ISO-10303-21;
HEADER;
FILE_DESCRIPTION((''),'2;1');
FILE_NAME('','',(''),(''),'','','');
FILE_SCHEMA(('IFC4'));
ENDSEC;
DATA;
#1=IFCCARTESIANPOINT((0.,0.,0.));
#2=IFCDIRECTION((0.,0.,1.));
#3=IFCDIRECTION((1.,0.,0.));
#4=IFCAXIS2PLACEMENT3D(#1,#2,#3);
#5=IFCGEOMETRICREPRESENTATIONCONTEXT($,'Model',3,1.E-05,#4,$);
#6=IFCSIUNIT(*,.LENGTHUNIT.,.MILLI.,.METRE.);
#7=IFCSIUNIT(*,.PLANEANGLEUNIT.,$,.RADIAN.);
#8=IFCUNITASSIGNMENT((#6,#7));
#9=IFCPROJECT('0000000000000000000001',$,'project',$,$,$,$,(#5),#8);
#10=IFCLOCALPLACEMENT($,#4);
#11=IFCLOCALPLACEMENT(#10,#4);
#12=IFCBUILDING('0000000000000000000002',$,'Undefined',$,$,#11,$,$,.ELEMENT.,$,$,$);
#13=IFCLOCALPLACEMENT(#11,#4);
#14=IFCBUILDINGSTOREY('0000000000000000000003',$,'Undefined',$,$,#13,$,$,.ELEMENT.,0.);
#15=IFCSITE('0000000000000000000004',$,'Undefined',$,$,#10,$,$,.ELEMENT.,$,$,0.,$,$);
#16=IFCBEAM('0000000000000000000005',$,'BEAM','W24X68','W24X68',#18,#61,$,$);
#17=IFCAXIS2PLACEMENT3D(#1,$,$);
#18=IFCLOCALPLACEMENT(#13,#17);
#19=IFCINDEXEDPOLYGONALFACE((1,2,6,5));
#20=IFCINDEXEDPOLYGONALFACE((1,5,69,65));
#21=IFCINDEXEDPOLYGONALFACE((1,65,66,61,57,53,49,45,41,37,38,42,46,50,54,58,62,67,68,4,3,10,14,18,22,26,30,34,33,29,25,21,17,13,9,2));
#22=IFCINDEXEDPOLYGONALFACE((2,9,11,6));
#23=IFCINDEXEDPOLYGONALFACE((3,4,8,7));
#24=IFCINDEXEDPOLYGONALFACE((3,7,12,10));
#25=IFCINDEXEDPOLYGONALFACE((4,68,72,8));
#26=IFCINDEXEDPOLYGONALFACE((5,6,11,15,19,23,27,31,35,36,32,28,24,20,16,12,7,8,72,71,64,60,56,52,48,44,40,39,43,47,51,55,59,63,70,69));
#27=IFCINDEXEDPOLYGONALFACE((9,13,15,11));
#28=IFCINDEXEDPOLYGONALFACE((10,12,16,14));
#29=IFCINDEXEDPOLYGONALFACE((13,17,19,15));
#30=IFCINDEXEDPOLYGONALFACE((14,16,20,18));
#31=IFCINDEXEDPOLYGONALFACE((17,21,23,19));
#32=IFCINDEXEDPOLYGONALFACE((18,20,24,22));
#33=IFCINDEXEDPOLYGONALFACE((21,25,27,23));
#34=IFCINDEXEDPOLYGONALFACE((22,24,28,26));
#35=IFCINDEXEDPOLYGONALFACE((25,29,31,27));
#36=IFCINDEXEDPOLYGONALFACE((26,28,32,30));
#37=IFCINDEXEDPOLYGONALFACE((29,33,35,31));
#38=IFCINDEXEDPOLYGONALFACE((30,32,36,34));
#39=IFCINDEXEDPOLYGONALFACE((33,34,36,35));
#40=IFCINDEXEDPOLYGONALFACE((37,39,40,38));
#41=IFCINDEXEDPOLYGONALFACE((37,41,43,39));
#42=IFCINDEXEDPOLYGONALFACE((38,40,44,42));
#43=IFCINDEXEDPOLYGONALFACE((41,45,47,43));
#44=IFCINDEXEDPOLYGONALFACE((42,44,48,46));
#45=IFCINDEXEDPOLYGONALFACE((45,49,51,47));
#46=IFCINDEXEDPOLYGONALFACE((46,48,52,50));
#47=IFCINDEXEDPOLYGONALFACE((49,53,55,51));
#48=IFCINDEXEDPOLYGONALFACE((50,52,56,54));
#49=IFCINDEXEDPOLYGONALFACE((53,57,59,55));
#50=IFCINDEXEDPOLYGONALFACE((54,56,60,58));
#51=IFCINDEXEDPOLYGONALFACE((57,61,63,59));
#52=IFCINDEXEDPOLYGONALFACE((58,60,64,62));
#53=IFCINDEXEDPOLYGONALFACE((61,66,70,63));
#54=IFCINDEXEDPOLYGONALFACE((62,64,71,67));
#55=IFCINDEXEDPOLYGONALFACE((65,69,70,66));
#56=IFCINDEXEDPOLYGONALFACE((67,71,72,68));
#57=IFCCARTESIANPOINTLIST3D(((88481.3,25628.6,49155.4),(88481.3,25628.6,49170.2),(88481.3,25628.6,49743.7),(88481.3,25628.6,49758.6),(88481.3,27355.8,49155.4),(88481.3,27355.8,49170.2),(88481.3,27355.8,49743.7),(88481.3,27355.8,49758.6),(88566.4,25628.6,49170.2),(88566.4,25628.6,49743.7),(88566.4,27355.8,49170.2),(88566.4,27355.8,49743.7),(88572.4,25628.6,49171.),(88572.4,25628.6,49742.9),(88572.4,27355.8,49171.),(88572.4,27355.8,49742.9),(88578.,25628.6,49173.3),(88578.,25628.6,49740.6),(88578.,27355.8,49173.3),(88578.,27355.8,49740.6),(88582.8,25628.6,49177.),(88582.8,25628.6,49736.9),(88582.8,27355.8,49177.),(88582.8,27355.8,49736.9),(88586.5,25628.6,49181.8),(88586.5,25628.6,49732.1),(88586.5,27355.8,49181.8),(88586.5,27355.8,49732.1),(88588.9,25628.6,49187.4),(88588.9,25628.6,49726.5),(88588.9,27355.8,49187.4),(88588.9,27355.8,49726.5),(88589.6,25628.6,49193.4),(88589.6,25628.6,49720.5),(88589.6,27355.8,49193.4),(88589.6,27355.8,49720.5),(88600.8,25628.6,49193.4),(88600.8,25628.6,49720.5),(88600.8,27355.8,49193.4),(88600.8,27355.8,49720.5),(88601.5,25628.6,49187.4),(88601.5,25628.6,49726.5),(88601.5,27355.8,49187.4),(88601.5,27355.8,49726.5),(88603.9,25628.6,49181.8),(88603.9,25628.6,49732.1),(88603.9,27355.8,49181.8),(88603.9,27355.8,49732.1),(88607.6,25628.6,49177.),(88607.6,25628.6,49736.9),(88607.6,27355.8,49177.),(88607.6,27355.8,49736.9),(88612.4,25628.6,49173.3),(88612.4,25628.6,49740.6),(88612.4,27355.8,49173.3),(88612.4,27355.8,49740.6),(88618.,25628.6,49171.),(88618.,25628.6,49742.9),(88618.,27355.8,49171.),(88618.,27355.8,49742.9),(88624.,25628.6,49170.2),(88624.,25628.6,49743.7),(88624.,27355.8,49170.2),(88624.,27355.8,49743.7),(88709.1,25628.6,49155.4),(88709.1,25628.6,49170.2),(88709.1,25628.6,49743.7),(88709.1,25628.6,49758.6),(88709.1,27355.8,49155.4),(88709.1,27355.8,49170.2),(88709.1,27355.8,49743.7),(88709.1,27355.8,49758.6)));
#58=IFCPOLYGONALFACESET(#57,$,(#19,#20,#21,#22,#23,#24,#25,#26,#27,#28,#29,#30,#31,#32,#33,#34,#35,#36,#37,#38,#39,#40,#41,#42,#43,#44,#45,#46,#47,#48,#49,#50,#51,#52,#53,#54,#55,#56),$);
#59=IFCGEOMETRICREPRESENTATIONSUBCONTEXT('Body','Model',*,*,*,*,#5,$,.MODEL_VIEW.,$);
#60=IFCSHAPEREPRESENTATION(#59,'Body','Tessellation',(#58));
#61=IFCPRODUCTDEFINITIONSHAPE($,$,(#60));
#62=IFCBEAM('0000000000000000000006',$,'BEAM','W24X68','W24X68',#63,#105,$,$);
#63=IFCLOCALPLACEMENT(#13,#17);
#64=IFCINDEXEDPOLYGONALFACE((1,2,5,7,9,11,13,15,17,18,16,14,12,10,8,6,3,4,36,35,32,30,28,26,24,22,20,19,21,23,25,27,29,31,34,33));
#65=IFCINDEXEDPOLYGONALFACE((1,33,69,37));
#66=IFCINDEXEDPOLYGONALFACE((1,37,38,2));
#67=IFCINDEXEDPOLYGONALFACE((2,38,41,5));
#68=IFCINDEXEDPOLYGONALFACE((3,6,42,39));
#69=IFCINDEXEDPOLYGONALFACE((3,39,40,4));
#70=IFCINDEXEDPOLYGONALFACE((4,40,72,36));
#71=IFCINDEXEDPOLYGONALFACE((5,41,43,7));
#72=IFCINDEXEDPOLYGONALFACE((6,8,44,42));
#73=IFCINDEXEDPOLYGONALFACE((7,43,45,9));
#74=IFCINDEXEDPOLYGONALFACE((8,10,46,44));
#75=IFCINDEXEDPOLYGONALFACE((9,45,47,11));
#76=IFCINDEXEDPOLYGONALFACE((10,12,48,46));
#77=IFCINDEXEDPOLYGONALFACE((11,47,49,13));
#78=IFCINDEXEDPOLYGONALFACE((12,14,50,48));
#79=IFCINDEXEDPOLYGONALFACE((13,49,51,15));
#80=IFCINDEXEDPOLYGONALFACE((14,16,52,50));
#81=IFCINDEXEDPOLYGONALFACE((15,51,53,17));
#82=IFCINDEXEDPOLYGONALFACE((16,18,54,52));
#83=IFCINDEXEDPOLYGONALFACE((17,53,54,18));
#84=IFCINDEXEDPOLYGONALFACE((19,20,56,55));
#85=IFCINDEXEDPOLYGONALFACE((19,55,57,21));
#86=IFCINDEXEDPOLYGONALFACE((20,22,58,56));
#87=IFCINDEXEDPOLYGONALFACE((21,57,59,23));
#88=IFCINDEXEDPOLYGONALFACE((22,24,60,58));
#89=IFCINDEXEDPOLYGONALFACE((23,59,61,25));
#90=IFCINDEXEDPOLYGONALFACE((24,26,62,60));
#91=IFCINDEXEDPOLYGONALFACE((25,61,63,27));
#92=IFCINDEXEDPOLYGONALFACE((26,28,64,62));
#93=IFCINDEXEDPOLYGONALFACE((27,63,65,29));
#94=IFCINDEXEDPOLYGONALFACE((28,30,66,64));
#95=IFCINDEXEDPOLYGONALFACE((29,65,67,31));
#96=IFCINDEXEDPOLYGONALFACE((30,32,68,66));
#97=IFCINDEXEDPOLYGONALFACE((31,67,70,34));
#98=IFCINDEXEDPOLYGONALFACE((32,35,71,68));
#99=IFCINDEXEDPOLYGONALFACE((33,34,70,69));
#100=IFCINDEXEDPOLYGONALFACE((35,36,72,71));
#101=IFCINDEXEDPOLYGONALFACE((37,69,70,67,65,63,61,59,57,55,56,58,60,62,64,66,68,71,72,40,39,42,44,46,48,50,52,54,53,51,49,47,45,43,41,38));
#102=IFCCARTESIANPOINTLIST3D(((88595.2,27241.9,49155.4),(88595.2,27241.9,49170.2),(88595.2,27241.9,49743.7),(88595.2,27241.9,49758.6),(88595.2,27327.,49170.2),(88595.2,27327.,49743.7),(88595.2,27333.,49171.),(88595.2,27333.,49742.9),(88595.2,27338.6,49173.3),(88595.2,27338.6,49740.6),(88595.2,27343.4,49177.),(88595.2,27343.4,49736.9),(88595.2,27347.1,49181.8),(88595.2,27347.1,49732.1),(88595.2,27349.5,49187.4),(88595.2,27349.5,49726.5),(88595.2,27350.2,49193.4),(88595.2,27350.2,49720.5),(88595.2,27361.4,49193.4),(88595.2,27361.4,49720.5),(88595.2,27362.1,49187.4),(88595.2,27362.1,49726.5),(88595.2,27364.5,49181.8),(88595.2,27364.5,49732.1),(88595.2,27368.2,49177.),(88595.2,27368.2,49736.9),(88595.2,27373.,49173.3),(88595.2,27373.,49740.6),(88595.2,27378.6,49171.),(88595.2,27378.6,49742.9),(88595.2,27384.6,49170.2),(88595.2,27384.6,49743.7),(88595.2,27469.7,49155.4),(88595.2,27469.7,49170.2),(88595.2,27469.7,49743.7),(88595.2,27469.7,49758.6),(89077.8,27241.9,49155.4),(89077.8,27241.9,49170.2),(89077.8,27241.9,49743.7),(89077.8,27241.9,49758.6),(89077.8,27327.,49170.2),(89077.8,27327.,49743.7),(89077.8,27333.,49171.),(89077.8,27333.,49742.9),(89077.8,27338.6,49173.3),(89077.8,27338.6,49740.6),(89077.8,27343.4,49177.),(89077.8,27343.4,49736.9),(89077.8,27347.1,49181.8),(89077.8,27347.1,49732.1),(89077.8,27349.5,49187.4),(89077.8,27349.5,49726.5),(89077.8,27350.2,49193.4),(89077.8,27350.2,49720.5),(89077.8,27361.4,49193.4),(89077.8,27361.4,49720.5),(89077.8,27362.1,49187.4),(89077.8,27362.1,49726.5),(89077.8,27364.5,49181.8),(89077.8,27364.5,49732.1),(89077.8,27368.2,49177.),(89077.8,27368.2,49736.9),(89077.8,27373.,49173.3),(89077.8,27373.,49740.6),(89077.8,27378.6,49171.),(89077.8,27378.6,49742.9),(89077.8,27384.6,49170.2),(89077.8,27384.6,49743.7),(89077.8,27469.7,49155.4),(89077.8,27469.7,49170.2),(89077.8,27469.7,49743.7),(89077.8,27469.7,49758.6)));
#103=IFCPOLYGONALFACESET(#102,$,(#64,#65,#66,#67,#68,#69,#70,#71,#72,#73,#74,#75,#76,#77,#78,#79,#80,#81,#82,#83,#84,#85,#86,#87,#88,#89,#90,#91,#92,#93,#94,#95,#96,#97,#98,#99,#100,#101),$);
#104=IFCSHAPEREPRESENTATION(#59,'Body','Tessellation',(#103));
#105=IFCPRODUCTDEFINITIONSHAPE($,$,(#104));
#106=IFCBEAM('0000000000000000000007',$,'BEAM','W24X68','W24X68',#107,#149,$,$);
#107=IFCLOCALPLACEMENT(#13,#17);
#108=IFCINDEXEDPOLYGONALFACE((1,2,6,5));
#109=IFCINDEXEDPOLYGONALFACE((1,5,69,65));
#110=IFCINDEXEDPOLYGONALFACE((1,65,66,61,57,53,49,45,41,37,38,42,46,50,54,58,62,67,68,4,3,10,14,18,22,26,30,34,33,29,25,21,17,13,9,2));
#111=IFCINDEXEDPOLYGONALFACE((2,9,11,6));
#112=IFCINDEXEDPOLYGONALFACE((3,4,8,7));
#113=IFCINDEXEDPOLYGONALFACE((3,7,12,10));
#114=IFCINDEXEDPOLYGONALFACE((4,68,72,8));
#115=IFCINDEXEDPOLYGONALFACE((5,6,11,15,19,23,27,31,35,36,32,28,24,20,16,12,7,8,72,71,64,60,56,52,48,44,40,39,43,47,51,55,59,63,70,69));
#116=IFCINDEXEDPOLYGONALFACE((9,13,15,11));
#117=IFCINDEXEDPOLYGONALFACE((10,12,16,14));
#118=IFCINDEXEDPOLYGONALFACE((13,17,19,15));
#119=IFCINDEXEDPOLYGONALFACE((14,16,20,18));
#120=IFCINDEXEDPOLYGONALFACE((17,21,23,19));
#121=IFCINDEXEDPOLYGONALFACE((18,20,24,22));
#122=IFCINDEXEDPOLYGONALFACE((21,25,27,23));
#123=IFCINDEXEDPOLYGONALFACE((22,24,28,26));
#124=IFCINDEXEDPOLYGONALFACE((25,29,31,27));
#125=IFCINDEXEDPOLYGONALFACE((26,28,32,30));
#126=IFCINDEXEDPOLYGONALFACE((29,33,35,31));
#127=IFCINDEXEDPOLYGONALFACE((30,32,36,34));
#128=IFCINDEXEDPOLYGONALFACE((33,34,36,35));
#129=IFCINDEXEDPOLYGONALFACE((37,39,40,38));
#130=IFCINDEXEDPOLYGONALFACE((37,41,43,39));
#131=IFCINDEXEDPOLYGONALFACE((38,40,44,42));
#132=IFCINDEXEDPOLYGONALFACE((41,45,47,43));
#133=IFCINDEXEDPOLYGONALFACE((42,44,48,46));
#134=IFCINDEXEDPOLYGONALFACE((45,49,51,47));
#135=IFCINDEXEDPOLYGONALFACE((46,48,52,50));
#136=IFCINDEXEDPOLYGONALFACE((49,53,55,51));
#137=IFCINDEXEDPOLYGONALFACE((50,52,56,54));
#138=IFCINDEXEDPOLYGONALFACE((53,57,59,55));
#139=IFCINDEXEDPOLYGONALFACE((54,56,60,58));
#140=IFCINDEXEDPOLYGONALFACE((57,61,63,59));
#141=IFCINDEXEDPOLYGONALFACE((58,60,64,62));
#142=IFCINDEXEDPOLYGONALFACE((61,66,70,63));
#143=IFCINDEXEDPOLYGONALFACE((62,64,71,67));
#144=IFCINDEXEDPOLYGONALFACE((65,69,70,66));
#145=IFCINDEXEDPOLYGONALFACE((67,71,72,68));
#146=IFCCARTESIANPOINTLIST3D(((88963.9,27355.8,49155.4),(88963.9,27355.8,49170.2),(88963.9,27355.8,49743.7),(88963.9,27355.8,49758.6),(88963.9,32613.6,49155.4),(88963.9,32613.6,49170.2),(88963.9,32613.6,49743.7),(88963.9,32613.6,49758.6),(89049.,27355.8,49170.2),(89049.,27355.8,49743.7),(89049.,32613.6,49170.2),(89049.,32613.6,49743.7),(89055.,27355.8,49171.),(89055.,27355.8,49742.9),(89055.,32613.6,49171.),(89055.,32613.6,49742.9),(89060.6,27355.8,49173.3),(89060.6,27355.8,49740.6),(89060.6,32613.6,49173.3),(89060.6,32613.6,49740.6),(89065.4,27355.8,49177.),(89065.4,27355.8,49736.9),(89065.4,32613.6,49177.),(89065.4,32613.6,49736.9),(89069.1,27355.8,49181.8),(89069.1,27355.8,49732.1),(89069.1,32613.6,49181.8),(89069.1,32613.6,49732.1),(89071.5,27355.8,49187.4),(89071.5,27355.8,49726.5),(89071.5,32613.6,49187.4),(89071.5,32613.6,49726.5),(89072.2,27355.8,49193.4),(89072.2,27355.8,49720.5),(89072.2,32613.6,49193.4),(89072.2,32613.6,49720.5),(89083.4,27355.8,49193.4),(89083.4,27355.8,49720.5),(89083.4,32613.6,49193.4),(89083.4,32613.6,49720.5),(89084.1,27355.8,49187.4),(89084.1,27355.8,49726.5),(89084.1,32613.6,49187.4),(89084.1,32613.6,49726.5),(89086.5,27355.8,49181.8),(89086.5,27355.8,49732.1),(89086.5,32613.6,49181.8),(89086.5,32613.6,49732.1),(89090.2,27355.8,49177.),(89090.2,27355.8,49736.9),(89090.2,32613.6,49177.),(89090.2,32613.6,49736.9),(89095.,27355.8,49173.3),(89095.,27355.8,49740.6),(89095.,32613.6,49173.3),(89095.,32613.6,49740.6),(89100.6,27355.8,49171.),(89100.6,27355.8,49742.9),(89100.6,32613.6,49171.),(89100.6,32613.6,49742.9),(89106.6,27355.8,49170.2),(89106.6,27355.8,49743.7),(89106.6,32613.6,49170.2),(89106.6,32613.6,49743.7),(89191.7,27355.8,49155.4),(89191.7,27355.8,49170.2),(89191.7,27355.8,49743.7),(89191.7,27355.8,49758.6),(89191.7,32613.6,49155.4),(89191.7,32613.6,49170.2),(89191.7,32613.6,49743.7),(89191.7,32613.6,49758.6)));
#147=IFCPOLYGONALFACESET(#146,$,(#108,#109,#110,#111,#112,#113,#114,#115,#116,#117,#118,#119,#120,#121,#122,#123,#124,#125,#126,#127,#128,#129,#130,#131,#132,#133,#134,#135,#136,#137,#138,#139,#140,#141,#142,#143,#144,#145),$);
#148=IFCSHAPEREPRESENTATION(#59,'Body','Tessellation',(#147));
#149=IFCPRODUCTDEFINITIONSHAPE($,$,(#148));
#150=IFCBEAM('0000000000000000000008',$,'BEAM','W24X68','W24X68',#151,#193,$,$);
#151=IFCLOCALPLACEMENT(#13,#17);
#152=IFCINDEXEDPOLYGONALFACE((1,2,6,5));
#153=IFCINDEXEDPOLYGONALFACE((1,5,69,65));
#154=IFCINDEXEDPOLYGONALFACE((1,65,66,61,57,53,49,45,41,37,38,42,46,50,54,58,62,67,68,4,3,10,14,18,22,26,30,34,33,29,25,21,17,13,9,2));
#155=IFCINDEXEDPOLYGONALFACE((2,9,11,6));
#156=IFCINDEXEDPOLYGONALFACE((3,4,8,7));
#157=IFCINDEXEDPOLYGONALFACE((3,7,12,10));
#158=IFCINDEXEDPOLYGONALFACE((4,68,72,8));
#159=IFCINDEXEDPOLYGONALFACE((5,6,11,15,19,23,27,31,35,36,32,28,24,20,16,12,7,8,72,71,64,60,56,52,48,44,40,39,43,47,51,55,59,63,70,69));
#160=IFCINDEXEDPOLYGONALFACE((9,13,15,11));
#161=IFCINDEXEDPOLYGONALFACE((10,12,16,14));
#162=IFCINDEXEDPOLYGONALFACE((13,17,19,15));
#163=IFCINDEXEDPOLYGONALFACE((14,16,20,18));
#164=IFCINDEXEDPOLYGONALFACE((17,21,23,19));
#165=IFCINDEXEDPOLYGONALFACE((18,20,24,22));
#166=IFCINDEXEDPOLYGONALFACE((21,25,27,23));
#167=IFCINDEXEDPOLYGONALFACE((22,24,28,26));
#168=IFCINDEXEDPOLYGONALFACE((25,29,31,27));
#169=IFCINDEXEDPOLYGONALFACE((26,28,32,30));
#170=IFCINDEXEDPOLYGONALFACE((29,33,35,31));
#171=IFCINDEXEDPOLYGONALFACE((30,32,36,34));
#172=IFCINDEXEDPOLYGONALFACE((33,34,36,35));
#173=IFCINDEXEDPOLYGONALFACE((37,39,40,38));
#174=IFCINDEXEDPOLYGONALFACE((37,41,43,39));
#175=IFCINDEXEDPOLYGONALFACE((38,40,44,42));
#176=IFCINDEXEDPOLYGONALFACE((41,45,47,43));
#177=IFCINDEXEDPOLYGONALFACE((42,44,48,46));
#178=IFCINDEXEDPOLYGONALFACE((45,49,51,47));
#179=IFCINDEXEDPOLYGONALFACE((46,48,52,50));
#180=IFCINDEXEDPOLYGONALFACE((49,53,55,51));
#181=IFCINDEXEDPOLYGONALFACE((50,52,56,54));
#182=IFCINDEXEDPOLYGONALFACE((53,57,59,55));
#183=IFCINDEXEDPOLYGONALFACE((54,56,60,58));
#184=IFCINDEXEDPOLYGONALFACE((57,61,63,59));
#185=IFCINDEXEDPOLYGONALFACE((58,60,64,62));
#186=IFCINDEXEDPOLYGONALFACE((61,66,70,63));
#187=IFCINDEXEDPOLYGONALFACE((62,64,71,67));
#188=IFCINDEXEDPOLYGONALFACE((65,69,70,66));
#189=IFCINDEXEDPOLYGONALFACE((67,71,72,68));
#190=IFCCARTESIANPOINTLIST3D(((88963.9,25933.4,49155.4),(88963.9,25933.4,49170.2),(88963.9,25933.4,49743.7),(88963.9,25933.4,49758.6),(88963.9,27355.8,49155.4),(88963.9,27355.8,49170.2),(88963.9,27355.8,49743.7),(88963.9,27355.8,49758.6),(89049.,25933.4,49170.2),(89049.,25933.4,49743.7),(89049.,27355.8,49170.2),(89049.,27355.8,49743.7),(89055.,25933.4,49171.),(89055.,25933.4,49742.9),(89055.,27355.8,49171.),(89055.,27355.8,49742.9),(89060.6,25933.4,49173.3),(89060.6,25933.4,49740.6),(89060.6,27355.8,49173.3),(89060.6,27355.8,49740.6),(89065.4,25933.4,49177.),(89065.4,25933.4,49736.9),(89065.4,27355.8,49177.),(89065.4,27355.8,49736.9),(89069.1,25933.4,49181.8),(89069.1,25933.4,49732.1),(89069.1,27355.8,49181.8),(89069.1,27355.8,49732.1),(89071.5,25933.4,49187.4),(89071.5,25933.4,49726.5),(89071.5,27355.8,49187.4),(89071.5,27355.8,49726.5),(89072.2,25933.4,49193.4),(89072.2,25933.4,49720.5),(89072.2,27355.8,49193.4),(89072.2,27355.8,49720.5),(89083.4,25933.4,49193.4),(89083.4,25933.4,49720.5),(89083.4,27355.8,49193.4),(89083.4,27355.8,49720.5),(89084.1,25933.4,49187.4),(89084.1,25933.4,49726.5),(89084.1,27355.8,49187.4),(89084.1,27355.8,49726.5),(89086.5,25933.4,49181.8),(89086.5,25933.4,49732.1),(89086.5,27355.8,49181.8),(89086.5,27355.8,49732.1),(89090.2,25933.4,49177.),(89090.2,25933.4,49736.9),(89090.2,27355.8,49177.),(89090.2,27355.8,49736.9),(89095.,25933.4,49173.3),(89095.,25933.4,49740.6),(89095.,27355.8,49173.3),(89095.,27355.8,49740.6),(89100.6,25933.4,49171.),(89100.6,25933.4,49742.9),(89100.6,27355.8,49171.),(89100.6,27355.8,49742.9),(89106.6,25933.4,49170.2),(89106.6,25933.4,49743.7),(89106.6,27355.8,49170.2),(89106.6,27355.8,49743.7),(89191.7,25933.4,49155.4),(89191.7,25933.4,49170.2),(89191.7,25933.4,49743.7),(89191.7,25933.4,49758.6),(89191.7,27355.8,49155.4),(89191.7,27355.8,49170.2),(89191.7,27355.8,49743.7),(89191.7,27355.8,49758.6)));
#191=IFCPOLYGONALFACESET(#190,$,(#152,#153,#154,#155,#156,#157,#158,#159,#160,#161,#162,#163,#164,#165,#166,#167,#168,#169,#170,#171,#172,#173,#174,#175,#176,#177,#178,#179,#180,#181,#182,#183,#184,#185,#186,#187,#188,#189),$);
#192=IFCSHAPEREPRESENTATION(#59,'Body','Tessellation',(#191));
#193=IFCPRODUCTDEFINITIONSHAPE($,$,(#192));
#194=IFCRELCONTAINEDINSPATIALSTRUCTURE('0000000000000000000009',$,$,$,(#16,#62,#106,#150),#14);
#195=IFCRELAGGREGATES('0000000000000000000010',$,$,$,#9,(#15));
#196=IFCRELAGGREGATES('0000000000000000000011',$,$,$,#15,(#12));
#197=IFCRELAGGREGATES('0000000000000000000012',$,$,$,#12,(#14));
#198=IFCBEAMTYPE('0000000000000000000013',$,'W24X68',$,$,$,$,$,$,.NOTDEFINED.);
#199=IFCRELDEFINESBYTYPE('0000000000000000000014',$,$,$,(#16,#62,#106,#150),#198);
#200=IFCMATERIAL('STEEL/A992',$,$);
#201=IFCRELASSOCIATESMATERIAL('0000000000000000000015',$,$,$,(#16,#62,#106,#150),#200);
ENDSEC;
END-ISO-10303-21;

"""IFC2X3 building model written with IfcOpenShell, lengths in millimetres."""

from ifc_helpers import new_model, si_unit, frame, origin_with_axes, origin_2d_with_axis, place, context, subcontext, project, spatial, i_section, extrude, material, type_object, element, save


model = new_model("IFC2X3")

# Units and contexts
model_context = context("Model", 3, precision=1e-05, world=origin_with_axes())
body_context = subcontext(model_context, "Body", "Model", "MODEL_VIEW")
ifc_project = project(units=[si_unit("LENGTHUNIT", "METRE", prefix="MILLI"), si_unit("PLANEANGLEUNIT", "RADIAN")], contexts=[model_context])

# Site, building, storey
site_placement = place(None, origin_with_axes())
site = spatial("IfcSite", under=ifc_project, at=site_placement, Name="Undefined", CompositionType="ELEMENT", RefElevation=0.0)
building_placement = place(site_placement, origin_with_axes())
building = spatial("IfcBuilding", under=site, at=building_placement, Name="Undefined", CompositionType="ELEMENT")
storey_placement = place(building_placement, origin_with_axes())
storey = spatial("IfcBuildingStorey", under=building, at=storey_placement, Name="Undefined", CompositionType="ELEMENT", Elevation=0.0)

# Shared definitions
ifc_material = material(Name="STEEL/A992")

# Beams
beam_type = type_object("IfcBeamType", Name="W24X68", PredefinedType="NOTDEFINED")
for number, where, z_axis, x_axis, name in (
    (1, (88595.2, 25628.6, 49457.0), (0.0, 0.0, 1.0), (0.0, 1.0, 0.0), "BEAM"),
):
    element("IfcBeam", number, at=place(storey_placement, frame(where, z_axis=z_axis, x_axis=x_axis)), inside=storey, type_object=beam_type, material=ifc_material, Name=name, Description="W24X68", ObjectType="W24X68", context=body_context, shape_type="SweptSolid", body=[
        extrude(i_section(OverallWidth=227.8, OverallDepth=603.2, WebThickness=11.1, FlangeThickness=14.9, FilletRadius=23.2, at=origin_2d_with_axis()), frame((1727.2, 0.0, 0.0), z_axis=(-1.0, 0.0, 0.0), x_axis=(0.0, -1.0, 0.0)), (0.0, 0.0, 1.0), 1727.2),
    ])
beam_1_placement = place(storey_placement, frame((88595.2, 27355.8, 49457.0), z_axis=(0.0, 0.0, 1.0), x_axis=(1.0, 0.0, 0.0)))
element("IfcBeam", 2, at=beam_1_placement, inside=storey, type_object=beam_type, material=ifc_material, Name="BEAM", Description="W24X68", ObjectType="W24X68", context=body_context, shape_type="SweptSolid", body=[
    extrude(i_section(OverallWidth=227.8, OverallDepth=603.2, WebThickness=11.1, FlangeThickness=14.9, FilletRadius=23.2, at=origin_2d_with_axis()), frame((482.6, 0.0, 0.0), z_axis=(-1.0, 0.0, 0.0), x_axis=(0.0, -1.0, 0.0)), (0.0, 0.0, 1.0), 482.6),
])
beam_2_placement = place(storey_placement, frame((89077.8, 27355.8, 49457.0), z_axis=(0.0, 0.0, 1.0), x_axis=(0.0, 1.0, 0.0)))
element("IfcBeam", 3, at=beam_2_placement, inside=storey, type_object=beam_type, material=ifc_material, Name="BEAM", Description="W24X68", ObjectType="W24X68", context=body_context, shape_type="SweptSolid", body=[
    extrude(i_section(OverallWidth=227.8, OverallDepth=603.2, WebThickness=11.1, FlangeThickness=14.9, FilletRadius=23.2, at=origin_2d_with_axis()), frame((5257.8, 0.0, 0.0), z_axis=(-1.0, 0.0, 0.0), x_axis=(0.0, -1.0, 0.0)), (0.0, 0.0, 1.0), 5257.8),
])
beam_3_placement = place(storey_placement, frame((89077.8, 25933.4, 49457.0), z_axis=(0.0, 0.0, 1.0), x_axis=(0.0, 1.0, 0.0)))
element("IfcBeam", 4, at=beam_3_placement, inside=storey, type_object=beam_type, material=ifc_material, Name="BEAM", Description="W24X68", ObjectType="W24X68", context=body_context, shape_type="SweptSolid", body=[
    extrude(i_section(OverallWidth=227.8, OverallDepth=603.2, WebThickness=11.1, FlangeThickness=14.9, FilletRadius=23.2, at=origin_2d_with_axis()), frame((1422.4, 0.0, 0.0), z_axis=(-1.0, 0.0, 0.0), x_axis=(0.0, -1.0, 0.0)), (0.0, 0.0, 1.0), 1422.4),
])

save(model, "model.ifc")
